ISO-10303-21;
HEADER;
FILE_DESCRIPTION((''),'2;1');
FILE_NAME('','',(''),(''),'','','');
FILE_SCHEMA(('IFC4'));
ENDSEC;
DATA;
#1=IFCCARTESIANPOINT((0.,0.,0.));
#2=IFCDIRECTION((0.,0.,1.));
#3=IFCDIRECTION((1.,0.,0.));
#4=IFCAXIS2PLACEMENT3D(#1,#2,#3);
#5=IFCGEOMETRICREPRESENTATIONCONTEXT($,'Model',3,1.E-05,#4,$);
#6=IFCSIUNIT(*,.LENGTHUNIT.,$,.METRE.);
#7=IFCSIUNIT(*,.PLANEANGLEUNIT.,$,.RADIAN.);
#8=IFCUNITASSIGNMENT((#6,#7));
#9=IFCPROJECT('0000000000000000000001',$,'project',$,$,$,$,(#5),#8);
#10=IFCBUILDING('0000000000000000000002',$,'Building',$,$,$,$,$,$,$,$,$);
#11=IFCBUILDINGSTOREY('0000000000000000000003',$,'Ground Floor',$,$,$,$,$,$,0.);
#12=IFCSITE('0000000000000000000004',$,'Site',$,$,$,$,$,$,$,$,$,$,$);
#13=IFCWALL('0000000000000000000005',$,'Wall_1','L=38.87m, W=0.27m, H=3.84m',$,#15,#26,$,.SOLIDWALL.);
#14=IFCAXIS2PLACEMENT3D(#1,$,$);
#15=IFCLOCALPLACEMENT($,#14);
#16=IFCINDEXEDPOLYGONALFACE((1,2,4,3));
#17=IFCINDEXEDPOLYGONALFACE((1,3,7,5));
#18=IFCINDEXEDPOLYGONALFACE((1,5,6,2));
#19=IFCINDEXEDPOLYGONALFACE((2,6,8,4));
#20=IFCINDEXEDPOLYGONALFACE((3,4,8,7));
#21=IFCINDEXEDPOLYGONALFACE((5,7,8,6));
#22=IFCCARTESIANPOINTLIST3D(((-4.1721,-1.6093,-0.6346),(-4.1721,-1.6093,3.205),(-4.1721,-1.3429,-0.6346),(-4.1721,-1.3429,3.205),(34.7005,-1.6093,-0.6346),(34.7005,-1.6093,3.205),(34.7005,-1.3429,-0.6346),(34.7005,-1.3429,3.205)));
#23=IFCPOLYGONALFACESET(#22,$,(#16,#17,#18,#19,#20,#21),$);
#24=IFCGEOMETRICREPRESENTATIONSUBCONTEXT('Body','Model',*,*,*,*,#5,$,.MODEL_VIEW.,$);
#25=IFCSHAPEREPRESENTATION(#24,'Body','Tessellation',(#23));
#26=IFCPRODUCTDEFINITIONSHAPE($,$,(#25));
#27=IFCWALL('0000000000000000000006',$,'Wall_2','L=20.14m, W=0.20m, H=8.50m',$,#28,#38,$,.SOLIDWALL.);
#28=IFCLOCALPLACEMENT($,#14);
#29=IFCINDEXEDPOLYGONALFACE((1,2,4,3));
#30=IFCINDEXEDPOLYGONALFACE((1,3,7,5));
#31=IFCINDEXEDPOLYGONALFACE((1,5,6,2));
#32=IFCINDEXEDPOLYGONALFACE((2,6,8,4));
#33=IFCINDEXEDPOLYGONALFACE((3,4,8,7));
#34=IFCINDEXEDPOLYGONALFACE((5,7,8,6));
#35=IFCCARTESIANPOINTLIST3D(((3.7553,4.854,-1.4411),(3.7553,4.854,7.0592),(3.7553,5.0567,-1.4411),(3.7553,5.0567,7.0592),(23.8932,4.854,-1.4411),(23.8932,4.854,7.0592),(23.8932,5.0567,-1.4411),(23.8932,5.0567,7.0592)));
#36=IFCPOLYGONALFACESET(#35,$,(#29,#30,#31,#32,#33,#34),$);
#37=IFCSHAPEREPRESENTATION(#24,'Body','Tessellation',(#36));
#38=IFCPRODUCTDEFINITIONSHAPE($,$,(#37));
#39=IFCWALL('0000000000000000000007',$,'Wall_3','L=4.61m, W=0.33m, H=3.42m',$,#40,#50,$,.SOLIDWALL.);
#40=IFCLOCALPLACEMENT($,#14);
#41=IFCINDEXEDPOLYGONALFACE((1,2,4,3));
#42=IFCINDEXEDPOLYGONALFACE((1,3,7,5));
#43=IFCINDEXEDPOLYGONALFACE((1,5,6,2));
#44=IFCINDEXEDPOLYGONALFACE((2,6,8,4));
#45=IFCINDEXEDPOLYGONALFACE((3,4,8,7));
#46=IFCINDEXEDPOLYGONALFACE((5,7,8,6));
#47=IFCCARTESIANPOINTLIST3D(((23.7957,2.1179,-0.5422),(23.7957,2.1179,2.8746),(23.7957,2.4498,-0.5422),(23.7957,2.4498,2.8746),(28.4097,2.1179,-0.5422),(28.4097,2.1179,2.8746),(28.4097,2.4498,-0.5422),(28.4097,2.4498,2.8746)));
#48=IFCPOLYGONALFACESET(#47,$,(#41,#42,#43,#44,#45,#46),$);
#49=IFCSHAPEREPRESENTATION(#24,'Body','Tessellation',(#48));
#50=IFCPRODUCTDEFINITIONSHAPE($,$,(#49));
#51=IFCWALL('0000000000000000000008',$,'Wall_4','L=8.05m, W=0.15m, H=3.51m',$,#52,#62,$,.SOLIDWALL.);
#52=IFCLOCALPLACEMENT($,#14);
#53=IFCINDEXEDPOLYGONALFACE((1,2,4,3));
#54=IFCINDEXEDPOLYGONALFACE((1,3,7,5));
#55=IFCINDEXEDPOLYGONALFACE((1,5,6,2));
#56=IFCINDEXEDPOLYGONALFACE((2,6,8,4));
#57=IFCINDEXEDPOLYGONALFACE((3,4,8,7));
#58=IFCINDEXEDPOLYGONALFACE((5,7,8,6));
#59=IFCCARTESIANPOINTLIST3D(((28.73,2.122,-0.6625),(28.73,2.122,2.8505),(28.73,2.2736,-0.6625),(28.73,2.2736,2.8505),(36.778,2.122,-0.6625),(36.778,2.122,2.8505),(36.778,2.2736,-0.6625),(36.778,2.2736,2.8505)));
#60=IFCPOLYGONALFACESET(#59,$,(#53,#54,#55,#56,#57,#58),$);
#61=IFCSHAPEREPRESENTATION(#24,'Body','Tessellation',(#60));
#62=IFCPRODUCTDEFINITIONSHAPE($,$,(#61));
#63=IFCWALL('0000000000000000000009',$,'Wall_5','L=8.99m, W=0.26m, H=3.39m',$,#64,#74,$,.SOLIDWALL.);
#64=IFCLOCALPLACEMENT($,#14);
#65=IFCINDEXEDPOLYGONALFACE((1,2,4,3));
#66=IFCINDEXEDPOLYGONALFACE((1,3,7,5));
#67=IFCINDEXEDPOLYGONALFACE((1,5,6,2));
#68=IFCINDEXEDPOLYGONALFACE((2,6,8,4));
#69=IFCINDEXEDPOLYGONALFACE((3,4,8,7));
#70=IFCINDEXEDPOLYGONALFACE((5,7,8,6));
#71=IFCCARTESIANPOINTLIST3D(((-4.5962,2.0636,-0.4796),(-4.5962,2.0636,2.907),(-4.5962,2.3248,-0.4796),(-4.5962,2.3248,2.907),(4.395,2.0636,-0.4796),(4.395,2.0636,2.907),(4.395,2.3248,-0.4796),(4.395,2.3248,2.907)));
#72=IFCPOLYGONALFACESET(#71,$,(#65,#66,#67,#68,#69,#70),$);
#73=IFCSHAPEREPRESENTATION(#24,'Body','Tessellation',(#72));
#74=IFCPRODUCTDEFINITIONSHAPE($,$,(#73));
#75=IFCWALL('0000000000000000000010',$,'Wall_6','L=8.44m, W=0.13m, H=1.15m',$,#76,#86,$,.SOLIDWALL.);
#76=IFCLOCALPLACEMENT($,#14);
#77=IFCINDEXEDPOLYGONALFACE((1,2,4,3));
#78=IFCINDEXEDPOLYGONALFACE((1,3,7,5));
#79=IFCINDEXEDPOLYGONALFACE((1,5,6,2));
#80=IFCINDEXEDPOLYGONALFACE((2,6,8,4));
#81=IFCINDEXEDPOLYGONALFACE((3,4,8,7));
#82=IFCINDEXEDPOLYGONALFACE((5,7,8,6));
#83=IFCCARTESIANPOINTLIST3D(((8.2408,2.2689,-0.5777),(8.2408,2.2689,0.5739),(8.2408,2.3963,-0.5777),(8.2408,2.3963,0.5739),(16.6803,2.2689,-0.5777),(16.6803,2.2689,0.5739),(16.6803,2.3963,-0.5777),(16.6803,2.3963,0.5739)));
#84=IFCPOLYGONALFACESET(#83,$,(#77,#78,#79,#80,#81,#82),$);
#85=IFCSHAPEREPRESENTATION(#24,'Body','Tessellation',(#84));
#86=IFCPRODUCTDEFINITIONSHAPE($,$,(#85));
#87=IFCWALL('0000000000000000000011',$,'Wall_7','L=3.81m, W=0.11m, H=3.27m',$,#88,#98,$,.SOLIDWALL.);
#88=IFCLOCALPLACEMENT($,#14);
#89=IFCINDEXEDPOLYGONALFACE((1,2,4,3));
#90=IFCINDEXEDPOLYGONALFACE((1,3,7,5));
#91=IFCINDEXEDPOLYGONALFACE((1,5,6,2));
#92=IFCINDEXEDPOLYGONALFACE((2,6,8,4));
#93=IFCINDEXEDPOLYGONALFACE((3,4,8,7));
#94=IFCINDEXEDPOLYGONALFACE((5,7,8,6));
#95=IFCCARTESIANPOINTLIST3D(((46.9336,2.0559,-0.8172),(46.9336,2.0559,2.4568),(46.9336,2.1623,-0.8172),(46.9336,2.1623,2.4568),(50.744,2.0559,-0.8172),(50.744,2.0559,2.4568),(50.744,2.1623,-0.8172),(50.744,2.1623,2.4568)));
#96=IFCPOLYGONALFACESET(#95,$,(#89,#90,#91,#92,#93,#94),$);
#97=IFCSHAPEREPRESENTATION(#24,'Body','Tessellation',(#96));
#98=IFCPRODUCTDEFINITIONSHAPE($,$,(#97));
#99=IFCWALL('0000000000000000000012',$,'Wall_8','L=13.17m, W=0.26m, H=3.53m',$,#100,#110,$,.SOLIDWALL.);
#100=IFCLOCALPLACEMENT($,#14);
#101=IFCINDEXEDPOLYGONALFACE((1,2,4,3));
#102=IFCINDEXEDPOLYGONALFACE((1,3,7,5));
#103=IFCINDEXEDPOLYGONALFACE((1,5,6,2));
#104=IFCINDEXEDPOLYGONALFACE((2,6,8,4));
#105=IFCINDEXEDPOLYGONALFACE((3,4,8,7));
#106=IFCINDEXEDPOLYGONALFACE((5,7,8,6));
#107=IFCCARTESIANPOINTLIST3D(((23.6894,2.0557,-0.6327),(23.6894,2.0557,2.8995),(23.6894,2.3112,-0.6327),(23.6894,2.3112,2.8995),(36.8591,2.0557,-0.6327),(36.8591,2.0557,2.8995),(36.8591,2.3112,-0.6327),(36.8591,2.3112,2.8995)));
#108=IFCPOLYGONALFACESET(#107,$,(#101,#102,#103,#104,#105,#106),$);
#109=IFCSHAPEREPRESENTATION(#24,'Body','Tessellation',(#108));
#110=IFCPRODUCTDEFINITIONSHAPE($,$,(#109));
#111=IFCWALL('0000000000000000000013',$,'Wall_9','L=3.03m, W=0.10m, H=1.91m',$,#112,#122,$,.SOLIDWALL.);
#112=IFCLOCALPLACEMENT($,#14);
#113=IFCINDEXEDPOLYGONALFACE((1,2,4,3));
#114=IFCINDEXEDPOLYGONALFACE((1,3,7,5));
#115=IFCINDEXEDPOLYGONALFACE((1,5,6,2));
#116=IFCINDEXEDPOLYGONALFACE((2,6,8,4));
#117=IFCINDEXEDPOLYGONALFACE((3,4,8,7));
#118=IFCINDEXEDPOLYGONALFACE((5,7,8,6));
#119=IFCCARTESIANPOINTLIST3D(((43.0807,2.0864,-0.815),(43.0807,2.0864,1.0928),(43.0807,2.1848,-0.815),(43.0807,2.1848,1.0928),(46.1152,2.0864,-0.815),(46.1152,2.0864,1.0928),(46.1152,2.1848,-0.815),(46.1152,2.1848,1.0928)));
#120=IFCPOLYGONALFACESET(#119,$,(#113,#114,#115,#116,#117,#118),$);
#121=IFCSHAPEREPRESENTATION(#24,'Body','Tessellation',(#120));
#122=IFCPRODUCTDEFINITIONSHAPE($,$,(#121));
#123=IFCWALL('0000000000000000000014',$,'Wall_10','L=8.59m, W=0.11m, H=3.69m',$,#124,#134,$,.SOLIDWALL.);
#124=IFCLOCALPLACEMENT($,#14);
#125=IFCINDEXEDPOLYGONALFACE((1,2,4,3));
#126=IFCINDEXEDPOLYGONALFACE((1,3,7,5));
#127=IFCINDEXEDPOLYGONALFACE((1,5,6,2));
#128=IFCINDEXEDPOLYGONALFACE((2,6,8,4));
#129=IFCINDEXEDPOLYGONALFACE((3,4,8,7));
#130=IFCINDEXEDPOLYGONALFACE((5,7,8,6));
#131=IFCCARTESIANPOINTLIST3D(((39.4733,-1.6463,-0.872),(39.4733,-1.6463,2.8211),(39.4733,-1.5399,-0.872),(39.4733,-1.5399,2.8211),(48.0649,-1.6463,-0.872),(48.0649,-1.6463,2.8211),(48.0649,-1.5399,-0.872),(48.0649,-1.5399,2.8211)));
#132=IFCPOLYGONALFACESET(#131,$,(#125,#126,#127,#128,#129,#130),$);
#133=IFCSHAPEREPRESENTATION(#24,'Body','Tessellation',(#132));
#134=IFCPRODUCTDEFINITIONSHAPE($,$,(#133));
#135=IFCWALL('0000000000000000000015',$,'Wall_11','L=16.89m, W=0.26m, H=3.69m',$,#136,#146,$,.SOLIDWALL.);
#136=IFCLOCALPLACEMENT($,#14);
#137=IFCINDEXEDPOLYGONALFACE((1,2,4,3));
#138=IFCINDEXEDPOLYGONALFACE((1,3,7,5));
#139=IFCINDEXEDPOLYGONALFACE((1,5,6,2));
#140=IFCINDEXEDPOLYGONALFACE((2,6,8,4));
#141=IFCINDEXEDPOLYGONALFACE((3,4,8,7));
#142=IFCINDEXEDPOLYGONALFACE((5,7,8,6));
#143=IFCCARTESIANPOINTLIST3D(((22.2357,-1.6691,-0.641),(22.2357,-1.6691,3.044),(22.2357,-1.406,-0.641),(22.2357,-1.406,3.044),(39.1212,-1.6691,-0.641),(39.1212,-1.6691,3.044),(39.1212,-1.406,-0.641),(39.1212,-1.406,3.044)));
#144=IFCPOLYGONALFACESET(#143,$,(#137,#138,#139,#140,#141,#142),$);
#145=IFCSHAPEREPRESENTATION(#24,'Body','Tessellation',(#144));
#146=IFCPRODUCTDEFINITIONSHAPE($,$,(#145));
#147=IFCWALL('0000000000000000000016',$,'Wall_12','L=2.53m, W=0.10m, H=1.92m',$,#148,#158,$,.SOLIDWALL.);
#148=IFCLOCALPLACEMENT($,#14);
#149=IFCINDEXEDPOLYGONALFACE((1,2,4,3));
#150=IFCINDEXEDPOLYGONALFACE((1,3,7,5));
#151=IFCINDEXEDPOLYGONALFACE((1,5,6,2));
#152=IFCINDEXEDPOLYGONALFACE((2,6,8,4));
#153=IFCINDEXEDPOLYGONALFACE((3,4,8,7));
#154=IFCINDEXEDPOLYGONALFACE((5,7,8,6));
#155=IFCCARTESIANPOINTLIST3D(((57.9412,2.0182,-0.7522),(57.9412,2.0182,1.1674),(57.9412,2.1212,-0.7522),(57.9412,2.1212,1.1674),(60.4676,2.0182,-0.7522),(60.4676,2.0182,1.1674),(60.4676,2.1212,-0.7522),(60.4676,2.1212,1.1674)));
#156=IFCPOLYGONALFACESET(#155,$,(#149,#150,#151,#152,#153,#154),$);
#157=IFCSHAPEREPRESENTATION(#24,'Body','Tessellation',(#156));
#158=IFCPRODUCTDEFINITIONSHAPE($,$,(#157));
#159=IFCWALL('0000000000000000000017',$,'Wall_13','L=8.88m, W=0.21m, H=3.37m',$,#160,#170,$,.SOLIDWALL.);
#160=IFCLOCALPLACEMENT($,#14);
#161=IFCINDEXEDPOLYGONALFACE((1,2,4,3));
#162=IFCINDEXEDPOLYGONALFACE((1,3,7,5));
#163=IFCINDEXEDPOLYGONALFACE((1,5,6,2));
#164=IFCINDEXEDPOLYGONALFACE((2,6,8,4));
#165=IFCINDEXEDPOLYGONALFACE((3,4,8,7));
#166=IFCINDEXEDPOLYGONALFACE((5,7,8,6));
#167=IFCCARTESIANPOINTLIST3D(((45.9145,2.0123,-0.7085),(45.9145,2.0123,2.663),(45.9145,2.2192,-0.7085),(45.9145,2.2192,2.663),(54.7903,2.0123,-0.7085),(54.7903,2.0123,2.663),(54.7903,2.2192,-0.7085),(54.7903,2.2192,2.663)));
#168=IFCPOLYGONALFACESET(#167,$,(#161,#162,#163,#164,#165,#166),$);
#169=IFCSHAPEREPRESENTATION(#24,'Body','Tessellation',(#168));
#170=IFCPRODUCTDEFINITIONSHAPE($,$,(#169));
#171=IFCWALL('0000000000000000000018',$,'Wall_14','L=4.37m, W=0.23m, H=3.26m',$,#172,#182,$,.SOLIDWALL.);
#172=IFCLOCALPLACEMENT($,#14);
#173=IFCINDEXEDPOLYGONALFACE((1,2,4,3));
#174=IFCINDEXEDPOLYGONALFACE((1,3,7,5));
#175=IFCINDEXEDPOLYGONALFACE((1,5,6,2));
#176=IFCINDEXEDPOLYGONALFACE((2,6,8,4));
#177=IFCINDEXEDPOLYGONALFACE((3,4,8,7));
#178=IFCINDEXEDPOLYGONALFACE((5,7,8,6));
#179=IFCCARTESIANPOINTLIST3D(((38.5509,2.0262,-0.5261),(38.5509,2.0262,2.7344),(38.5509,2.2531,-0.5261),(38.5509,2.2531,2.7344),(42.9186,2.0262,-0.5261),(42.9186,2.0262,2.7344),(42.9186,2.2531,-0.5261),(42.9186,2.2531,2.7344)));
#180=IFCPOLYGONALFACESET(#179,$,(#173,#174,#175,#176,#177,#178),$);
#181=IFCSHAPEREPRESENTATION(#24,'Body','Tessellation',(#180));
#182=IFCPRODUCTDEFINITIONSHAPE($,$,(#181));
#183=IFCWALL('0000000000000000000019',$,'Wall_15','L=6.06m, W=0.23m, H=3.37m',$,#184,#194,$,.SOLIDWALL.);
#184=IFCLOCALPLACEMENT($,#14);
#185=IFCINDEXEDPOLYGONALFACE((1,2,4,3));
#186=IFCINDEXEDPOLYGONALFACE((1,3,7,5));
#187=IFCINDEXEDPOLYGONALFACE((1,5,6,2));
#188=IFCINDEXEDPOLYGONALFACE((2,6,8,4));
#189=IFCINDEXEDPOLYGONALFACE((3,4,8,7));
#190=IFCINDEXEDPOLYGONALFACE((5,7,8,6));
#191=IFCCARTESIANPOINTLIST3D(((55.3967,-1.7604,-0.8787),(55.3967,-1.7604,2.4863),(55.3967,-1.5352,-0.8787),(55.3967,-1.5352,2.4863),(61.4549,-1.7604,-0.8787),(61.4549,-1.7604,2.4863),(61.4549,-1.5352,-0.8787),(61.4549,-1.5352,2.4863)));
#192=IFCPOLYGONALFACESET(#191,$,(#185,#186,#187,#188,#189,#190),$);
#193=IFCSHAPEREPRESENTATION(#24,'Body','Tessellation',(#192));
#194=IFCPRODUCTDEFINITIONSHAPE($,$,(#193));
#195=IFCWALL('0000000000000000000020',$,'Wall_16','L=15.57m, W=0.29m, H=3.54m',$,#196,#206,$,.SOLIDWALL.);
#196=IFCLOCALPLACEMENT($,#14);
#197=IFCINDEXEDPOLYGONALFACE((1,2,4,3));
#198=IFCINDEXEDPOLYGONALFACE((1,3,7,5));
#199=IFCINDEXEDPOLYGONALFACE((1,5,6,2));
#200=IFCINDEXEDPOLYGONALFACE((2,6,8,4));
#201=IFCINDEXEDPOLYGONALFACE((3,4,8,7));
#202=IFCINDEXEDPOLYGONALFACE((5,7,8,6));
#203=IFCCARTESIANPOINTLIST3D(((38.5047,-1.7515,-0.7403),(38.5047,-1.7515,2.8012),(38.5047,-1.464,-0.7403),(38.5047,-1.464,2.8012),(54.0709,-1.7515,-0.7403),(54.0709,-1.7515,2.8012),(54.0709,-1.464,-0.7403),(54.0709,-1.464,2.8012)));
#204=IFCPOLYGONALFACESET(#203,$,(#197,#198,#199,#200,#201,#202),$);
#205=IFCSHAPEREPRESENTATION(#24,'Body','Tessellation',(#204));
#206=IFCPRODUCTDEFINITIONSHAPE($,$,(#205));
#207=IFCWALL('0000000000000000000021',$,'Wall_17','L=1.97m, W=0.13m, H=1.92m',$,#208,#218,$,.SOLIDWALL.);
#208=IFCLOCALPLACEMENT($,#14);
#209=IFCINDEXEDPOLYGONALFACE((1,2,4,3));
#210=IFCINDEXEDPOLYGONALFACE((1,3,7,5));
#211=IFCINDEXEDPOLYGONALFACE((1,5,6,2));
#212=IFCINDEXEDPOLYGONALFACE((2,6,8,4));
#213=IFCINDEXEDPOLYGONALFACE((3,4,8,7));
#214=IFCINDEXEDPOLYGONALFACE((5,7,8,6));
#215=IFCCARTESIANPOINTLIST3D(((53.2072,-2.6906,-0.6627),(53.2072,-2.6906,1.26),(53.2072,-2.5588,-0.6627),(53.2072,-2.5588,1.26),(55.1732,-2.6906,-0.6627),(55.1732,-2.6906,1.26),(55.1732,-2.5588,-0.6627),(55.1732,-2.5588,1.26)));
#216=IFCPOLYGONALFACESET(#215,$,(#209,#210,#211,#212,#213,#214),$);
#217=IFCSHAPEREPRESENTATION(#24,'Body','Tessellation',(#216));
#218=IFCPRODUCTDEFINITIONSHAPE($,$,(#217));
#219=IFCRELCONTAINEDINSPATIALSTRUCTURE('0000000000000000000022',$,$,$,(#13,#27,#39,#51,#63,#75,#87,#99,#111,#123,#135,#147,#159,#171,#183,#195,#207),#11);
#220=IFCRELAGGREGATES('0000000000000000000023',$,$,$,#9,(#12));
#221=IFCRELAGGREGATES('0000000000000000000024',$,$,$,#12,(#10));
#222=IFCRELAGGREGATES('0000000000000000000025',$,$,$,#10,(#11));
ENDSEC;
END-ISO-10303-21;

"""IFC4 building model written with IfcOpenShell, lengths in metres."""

from ifc_helpers import new_model, si_unit, frame, origin_with_axes, origin_2d, context, subcontext, project, spatial, rectangle, extrude, element, save


model = new_model("IFC4")

# Units and contexts
model_context = context("Model", 3, precision=1e-05, world=origin_with_axes())
body_context = subcontext(model_context, "Body", "Model", "MODEL_VIEW")
ifc_project = project(units=[si_unit("LENGTHUNIT", "METRE"), si_unit("PLANEANGLEUNIT", "RADIAN")], contexts=[model_context])

# Site, building, storey
site = spatial("IfcSite", under=ifc_project, Name="Site")
building = spatial("IfcBuilding", under=site, Name="Building")
storey = spatial("IfcBuildingStorey", under=building, Name="Ground Floor", Elevation=0.0)

# Walls
element("IfcWall", 1, inside=storey, Name="Wall_1", Description="L=38.87m, W=0.27m, H=3.84m", PredefinedType="SOLIDWALL", context=body_context, shape_type="SweptSolid", body=[
    extrude(rectangle(XDim=38.8726, YDim=0.2664, at=origin_2d()), frame((15.2642, -1.4761, -0.6346), z_axis=(0.0, 0.0, 1.0), x_axis=(1.0, 0.0, 0.0)), (0.0, 0.0, 1.0), 3.8396),
])
element("IfcWall", 2, inside=storey, Name="Wall_2", Description="L=20.14m, W=0.20m, H=8.50m", PredefinedType="SOLIDWALL", context=body_context, shape_type="SweptSolid", body=[
    extrude(rectangle(XDim=20.1379, YDim=0.2027, at=origin_2d()), frame((13.8242, 4.9554, -1.4411), z_axis=(0.0, 0.0, 1.0), x_axis=(1.0, 0.0, 0.0)), (0.0, 0.0, 1.0), 8.5003),
])
element("IfcWall", 3, inside=storey, Name="Wall_3", Description="L=4.61m, W=0.33m, H=3.42m", PredefinedType="SOLIDWALL", context=body_context, shape_type="SweptSolid", body=[
    extrude(rectangle(XDim=4.6139, YDim=0.3319, at=origin_2d()), frame((26.1027, 2.2839, -0.5422), z_axis=(0.0, 0.0, 1.0), x_axis=(1.0, 0.0, 0.0)), (0.0, 0.0, 1.0), 3.4168),
])
element("IfcWall", 4, inside=storey, Name="Wall_4", Description="L=8.05m, W=0.15m, H=3.51m", PredefinedType="SOLIDWALL", context=body_context, shape_type="SweptSolid", body=[
    extrude(rectangle(XDim=8.0479, YDim=0.1517, at=origin_2d()), frame((32.754, 2.1978, -0.6625), z_axis=(0.0, 0.0, 1.0), x_axis=(1.0, 0.0, 0.0)), (0.0, 0.0, 1.0), 3.513),
])
element("IfcWall", 5, inside=storey, Name="Wall_5", Description="L=8.99m, W=0.26m, H=3.39m", PredefinedType="SOLIDWALL", context=body_context, shape_type="SweptSolid", body=[
    extrude(rectangle(XDim=8.9913, YDim=0.2612, at=origin_2d()), frame((-0.1006, 2.1942, -0.4796), z_axis=(0.0, 0.0, 1.0), x_axis=(1.0, 0.0, 0.0)), (0.0, 0.0, 1.0), 3.3866),
])
element("IfcWall", 6, inside=storey, Name="Wall_6", Description="L=8.44m, W=0.13m, H=1.15m", PredefinedType="SOLIDWALL", context=body_context, shape_type="SweptSolid", body=[
    extrude(rectangle(XDim=8.4396, YDim=0.1274, at=origin_2d()), frame((12.4605, 2.3326, -0.5777), z_axis=(0.0, 0.0, 1.0), x_axis=(1.0, 0.0, 0.0)), (0.0, 0.0, 1.0), 1.1516),
])
element("IfcWall", 7, inside=storey, Name="Wall_7", Description="L=3.81m, W=0.11m, H=3.27m", PredefinedType="SOLIDWALL", context=body_context, shape_type="SweptSolid", body=[
    extrude(rectangle(XDim=3.8104, YDim=0.1065, at=origin_2d()), frame((48.8388, 2.1091, -0.8172), z_axis=(0.0, 0.0, 1.0), x_axis=(1.0, 0.0, 0.0)), (0.0, 0.0, 1.0), 3.274),
])
element("IfcWall", 8, inside=storey, Name="Wall_8", Description="L=13.17m, W=0.26m, H=3.53m", PredefinedType="SOLIDWALL", context=body_context, shape_type="SweptSolid", body=[
    extrude(rectangle(XDim=13.1696, YDim=0.2554, at=origin_2d()), frame((30.2743, 2.1835, -0.6327), z_axis=(0.0, 0.0, 1.0), x_axis=(1.0, 0.0, 0.0)), (0.0, 0.0, 1.0), 3.5323),
])
element("IfcWall", 9, inside=storey, Name="Wall_9", Description="L=3.03m, W=0.10m, H=1.91m", PredefinedType="SOLIDWALL", context=body_context, shape_type="SweptSolid", body=[
    extrude(rectangle(XDim=3.0345, YDim=0.0984, at=origin_2d()), frame((44.598, 2.1356, -0.815), z_axis=(0.0, 0.0, 1.0), x_axis=(1.0, 0.0, 0.0)), (0.0, 0.0, 1.0), 1.9078),
])
element("IfcWall", 10, inside=storey, Name="Wall_10", Description="L=8.59m, W=0.11m, H=3.69m", PredefinedType="SOLIDWALL", context=body_context, shape_type="SweptSolid", body=[
    extrude(rectangle(XDim=8.5917, YDim=0.1064, at=origin_2d()), frame((43.7691, -1.5931, -0.872), z_axis=(0.0, 0.0, 1.0), x_axis=(1.0, 0.0, 0.0)), (0.0, 0.0, 1.0), 3.6931),
])
element("IfcWall", 11, inside=storey, Name="Wall_11", Description="L=16.89m, W=0.26m, H=3.69m", PredefinedType="SOLIDWALL", context=body_context, shape_type="SweptSolid", body=[
    extrude(rectangle(XDim=16.8855, YDim=0.2631, at=origin_2d()), frame((30.6785, -1.5375, -0.641), z_axis=(0.0, 0.0, 1.0), x_axis=(1.0, 0.0, 0.0)), (0.0, 0.0, 1.0), 3.685),
])
element("IfcWall", 12, inside=storey, Name="Wall_12", Description="L=2.53m, W=0.10m, H=1.92m", PredefinedType="SOLIDWALL", context=body_context, shape_type="SweptSolid", body=[
    extrude(rectangle(XDim=2.5264, YDim=0.1031, at=origin_2d()), frame((59.2044, 2.0697, -0.7522), z_axis=(0.0, 0.0, 1.0), x_axis=(1.0, 0.0, 0.0)), (0.0, 0.0, 1.0), 1.9196),
])
element("IfcWall", 13, inside=storey, Name="Wall_13", Description="L=8.88m, W=0.21m, H=3.37m", PredefinedType="SOLIDWALL", context=body_context, shape_type="SweptSolid", body=[
    extrude(rectangle(XDim=8.8758, YDim=0.2069, at=origin_2d()), frame((50.3524, 2.1157, -0.7085), z_axis=(0.0, 0.0, 1.0), x_axis=(1.0, 0.0, 0.0)), (0.0, 0.0, 1.0), 3.3715),
])
element("IfcWall", 14, inside=storey, Name="Wall_14", Description="L=4.37m, W=0.23m, H=3.26m", PredefinedType="SOLIDWALL", context=body_context, shape_type="SweptSolid", body=[
    extrude(rectangle(XDim=4.3676, YDim=0.2269, at=origin_2d()), frame((40.7348, 2.1397, -0.5261), z_axis=(0.0, 0.0, 1.0), x_axis=(1.0, 0.0, 0.0)), (0.0, 0.0, 1.0), 3.2605),
])
element("IfcWall", 15, inside=storey, Name="Wall_15", Description="L=6.06m, W=0.23m, H=3.37m", PredefinedType="SOLIDWALL", context=body_context, shape_type="SweptSolid", body=[
    extrude(rectangle(XDim=6.0583, YDim=0.2252, at=origin_2d()), frame((58.4258, -1.6478, -0.8787), z_axis=(0.0, 0.0, 1.0), x_axis=(1.0, 0.0, 0.0)), (0.0, 0.0, 1.0), 3.365),
])
element("IfcWall", 16, inside=storey, Name="Wall_16", Description="L=15.57m, W=0.29m, H=3.54m", PredefinedType="SOLIDWALL", context=body_context, shape_type="SweptSolid", body=[
    extrude(rectangle(XDim=15.5662, YDim=0.2875, at=origin_2d()), frame((46.2878, -1.6077, -0.7403), z_axis=(0.0, 0.0, 1.0), x_axis=(1.0, 0.0, 0.0)), (0.0, 0.0, 1.0), 3.5415),
])
element("IfcWall", 17, inside=storey, Name="Wall_17", Description="L=1.97m, W=0.13m, H=1.92m", PredefinedType="SOLIDWALL", context=body_context, shape_type="SweptSolid", body=[
    extrude(rectangle(XDim=1.966, YDim=0.1317, at=origin_2d()), frame((54.1902, -2.6247, -0.6627), z_axis=(0.0, 0.0, 1.0), x_axis=(1.0, 0.0, 0.0)), (0.0, 0.0, 1.0), 1.9227),
])

save(model, "model.ifc")
